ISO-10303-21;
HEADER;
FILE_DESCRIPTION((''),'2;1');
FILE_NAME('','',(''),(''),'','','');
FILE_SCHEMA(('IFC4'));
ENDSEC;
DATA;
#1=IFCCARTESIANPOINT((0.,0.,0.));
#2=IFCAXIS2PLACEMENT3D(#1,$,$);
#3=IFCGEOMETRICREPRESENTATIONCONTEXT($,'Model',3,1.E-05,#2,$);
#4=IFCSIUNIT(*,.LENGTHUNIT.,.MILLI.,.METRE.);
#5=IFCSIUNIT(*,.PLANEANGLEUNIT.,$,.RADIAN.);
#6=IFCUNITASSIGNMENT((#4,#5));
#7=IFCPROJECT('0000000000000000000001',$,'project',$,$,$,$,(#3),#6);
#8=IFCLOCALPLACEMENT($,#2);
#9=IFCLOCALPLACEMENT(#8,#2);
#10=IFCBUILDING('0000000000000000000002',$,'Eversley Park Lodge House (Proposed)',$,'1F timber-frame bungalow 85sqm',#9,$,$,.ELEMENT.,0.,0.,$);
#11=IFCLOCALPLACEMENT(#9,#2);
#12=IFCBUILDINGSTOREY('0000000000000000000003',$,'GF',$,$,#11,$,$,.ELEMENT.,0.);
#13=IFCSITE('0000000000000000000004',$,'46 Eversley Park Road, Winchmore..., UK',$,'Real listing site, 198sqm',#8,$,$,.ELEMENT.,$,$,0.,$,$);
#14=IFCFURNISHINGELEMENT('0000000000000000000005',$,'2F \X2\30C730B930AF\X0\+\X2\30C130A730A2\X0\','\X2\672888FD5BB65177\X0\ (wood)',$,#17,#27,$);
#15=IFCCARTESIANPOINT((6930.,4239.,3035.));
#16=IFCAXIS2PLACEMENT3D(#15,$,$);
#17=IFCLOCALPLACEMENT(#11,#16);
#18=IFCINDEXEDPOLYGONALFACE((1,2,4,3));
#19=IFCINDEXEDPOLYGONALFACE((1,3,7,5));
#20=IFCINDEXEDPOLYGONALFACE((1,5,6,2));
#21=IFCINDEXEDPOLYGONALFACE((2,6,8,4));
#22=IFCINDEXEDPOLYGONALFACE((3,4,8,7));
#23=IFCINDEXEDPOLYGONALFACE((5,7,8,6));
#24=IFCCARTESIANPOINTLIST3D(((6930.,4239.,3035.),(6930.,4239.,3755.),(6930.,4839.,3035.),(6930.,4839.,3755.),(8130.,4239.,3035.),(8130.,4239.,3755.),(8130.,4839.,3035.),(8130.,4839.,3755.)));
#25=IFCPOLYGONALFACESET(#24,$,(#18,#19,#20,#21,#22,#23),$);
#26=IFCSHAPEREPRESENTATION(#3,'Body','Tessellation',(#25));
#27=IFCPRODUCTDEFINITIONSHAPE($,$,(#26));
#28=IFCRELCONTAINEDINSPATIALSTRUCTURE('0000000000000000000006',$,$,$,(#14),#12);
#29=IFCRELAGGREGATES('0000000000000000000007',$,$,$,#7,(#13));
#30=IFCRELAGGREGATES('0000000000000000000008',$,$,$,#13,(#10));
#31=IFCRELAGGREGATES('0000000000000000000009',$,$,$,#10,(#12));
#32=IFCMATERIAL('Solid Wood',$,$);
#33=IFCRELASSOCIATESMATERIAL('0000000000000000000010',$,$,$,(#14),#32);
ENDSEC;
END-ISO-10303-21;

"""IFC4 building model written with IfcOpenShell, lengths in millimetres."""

from ifc_helpers import new_model, si_unit, frame, frame_2d, origin, place, context, project, spatial, rectangle, extrude, material, element, save


model = new_model("IFC4")

# Units and contexts
model_context = context("Model", 3, precision=1e-05, world=origin())
ifc_project = project(units=[si_unit("LENGTHUNIT", "METRE", prefix="MILLI"), si_unit("PLANEANGLEUNIT", "RADIAN")], contexts=[model_context])

# Site, building, storey
site_placement = place(None, origin())
site = spatial("IfcSite", under=ifc_project, at=site_placement, Name="46 Eversley Park Road, Winchmore..., UK", ObjectType="Real listing site, 198sqm", CompositionType="ELEMENT", RefElevation=0.0)
building_placement = place(site_placement, origin())
building = spatial("IfcBuilding", under=site, at=building_placement, Name="Eversley Park Lodge House (Proposed)", ObjectType="1F timber-frame bungalow 85sqm", CompositionType="ELEMENT", ElevationOfRefHeight=0.0, ElevationOfTerrain=0.0)
storey_placement = place(building_placement, origin())
storey = spatial("IfcBuildingStorey", under=building, at=storey_placement, Name="GF", CompositionType="ELEMENT", Elevation=0.0)

# Shared definitions
ifc_material_1 = material(Name="Solid Wood")

# Furnishing element
furnishing_1_placement = place(storey_placement, frame((6930.0, 4239.0, 3035.0)))
element("IfcFurnishingElement", 1, at=furnishing_1_placement, inside=storey, material=ifc_material_1, Name="2F デスク+チェア", Description="木製家具 (wood)", context=model_context, shape_type="SweptSolid", body=[
    extrude(rectangle(XDim=1200.0, YDim=600.0, at=frame_2d((600.0, 300.0))), frame((6930.0, 4239.0, 3035.0)), (0.0, 0.0, 1.0), 720.0),
])

save(model, "model.ifc")
